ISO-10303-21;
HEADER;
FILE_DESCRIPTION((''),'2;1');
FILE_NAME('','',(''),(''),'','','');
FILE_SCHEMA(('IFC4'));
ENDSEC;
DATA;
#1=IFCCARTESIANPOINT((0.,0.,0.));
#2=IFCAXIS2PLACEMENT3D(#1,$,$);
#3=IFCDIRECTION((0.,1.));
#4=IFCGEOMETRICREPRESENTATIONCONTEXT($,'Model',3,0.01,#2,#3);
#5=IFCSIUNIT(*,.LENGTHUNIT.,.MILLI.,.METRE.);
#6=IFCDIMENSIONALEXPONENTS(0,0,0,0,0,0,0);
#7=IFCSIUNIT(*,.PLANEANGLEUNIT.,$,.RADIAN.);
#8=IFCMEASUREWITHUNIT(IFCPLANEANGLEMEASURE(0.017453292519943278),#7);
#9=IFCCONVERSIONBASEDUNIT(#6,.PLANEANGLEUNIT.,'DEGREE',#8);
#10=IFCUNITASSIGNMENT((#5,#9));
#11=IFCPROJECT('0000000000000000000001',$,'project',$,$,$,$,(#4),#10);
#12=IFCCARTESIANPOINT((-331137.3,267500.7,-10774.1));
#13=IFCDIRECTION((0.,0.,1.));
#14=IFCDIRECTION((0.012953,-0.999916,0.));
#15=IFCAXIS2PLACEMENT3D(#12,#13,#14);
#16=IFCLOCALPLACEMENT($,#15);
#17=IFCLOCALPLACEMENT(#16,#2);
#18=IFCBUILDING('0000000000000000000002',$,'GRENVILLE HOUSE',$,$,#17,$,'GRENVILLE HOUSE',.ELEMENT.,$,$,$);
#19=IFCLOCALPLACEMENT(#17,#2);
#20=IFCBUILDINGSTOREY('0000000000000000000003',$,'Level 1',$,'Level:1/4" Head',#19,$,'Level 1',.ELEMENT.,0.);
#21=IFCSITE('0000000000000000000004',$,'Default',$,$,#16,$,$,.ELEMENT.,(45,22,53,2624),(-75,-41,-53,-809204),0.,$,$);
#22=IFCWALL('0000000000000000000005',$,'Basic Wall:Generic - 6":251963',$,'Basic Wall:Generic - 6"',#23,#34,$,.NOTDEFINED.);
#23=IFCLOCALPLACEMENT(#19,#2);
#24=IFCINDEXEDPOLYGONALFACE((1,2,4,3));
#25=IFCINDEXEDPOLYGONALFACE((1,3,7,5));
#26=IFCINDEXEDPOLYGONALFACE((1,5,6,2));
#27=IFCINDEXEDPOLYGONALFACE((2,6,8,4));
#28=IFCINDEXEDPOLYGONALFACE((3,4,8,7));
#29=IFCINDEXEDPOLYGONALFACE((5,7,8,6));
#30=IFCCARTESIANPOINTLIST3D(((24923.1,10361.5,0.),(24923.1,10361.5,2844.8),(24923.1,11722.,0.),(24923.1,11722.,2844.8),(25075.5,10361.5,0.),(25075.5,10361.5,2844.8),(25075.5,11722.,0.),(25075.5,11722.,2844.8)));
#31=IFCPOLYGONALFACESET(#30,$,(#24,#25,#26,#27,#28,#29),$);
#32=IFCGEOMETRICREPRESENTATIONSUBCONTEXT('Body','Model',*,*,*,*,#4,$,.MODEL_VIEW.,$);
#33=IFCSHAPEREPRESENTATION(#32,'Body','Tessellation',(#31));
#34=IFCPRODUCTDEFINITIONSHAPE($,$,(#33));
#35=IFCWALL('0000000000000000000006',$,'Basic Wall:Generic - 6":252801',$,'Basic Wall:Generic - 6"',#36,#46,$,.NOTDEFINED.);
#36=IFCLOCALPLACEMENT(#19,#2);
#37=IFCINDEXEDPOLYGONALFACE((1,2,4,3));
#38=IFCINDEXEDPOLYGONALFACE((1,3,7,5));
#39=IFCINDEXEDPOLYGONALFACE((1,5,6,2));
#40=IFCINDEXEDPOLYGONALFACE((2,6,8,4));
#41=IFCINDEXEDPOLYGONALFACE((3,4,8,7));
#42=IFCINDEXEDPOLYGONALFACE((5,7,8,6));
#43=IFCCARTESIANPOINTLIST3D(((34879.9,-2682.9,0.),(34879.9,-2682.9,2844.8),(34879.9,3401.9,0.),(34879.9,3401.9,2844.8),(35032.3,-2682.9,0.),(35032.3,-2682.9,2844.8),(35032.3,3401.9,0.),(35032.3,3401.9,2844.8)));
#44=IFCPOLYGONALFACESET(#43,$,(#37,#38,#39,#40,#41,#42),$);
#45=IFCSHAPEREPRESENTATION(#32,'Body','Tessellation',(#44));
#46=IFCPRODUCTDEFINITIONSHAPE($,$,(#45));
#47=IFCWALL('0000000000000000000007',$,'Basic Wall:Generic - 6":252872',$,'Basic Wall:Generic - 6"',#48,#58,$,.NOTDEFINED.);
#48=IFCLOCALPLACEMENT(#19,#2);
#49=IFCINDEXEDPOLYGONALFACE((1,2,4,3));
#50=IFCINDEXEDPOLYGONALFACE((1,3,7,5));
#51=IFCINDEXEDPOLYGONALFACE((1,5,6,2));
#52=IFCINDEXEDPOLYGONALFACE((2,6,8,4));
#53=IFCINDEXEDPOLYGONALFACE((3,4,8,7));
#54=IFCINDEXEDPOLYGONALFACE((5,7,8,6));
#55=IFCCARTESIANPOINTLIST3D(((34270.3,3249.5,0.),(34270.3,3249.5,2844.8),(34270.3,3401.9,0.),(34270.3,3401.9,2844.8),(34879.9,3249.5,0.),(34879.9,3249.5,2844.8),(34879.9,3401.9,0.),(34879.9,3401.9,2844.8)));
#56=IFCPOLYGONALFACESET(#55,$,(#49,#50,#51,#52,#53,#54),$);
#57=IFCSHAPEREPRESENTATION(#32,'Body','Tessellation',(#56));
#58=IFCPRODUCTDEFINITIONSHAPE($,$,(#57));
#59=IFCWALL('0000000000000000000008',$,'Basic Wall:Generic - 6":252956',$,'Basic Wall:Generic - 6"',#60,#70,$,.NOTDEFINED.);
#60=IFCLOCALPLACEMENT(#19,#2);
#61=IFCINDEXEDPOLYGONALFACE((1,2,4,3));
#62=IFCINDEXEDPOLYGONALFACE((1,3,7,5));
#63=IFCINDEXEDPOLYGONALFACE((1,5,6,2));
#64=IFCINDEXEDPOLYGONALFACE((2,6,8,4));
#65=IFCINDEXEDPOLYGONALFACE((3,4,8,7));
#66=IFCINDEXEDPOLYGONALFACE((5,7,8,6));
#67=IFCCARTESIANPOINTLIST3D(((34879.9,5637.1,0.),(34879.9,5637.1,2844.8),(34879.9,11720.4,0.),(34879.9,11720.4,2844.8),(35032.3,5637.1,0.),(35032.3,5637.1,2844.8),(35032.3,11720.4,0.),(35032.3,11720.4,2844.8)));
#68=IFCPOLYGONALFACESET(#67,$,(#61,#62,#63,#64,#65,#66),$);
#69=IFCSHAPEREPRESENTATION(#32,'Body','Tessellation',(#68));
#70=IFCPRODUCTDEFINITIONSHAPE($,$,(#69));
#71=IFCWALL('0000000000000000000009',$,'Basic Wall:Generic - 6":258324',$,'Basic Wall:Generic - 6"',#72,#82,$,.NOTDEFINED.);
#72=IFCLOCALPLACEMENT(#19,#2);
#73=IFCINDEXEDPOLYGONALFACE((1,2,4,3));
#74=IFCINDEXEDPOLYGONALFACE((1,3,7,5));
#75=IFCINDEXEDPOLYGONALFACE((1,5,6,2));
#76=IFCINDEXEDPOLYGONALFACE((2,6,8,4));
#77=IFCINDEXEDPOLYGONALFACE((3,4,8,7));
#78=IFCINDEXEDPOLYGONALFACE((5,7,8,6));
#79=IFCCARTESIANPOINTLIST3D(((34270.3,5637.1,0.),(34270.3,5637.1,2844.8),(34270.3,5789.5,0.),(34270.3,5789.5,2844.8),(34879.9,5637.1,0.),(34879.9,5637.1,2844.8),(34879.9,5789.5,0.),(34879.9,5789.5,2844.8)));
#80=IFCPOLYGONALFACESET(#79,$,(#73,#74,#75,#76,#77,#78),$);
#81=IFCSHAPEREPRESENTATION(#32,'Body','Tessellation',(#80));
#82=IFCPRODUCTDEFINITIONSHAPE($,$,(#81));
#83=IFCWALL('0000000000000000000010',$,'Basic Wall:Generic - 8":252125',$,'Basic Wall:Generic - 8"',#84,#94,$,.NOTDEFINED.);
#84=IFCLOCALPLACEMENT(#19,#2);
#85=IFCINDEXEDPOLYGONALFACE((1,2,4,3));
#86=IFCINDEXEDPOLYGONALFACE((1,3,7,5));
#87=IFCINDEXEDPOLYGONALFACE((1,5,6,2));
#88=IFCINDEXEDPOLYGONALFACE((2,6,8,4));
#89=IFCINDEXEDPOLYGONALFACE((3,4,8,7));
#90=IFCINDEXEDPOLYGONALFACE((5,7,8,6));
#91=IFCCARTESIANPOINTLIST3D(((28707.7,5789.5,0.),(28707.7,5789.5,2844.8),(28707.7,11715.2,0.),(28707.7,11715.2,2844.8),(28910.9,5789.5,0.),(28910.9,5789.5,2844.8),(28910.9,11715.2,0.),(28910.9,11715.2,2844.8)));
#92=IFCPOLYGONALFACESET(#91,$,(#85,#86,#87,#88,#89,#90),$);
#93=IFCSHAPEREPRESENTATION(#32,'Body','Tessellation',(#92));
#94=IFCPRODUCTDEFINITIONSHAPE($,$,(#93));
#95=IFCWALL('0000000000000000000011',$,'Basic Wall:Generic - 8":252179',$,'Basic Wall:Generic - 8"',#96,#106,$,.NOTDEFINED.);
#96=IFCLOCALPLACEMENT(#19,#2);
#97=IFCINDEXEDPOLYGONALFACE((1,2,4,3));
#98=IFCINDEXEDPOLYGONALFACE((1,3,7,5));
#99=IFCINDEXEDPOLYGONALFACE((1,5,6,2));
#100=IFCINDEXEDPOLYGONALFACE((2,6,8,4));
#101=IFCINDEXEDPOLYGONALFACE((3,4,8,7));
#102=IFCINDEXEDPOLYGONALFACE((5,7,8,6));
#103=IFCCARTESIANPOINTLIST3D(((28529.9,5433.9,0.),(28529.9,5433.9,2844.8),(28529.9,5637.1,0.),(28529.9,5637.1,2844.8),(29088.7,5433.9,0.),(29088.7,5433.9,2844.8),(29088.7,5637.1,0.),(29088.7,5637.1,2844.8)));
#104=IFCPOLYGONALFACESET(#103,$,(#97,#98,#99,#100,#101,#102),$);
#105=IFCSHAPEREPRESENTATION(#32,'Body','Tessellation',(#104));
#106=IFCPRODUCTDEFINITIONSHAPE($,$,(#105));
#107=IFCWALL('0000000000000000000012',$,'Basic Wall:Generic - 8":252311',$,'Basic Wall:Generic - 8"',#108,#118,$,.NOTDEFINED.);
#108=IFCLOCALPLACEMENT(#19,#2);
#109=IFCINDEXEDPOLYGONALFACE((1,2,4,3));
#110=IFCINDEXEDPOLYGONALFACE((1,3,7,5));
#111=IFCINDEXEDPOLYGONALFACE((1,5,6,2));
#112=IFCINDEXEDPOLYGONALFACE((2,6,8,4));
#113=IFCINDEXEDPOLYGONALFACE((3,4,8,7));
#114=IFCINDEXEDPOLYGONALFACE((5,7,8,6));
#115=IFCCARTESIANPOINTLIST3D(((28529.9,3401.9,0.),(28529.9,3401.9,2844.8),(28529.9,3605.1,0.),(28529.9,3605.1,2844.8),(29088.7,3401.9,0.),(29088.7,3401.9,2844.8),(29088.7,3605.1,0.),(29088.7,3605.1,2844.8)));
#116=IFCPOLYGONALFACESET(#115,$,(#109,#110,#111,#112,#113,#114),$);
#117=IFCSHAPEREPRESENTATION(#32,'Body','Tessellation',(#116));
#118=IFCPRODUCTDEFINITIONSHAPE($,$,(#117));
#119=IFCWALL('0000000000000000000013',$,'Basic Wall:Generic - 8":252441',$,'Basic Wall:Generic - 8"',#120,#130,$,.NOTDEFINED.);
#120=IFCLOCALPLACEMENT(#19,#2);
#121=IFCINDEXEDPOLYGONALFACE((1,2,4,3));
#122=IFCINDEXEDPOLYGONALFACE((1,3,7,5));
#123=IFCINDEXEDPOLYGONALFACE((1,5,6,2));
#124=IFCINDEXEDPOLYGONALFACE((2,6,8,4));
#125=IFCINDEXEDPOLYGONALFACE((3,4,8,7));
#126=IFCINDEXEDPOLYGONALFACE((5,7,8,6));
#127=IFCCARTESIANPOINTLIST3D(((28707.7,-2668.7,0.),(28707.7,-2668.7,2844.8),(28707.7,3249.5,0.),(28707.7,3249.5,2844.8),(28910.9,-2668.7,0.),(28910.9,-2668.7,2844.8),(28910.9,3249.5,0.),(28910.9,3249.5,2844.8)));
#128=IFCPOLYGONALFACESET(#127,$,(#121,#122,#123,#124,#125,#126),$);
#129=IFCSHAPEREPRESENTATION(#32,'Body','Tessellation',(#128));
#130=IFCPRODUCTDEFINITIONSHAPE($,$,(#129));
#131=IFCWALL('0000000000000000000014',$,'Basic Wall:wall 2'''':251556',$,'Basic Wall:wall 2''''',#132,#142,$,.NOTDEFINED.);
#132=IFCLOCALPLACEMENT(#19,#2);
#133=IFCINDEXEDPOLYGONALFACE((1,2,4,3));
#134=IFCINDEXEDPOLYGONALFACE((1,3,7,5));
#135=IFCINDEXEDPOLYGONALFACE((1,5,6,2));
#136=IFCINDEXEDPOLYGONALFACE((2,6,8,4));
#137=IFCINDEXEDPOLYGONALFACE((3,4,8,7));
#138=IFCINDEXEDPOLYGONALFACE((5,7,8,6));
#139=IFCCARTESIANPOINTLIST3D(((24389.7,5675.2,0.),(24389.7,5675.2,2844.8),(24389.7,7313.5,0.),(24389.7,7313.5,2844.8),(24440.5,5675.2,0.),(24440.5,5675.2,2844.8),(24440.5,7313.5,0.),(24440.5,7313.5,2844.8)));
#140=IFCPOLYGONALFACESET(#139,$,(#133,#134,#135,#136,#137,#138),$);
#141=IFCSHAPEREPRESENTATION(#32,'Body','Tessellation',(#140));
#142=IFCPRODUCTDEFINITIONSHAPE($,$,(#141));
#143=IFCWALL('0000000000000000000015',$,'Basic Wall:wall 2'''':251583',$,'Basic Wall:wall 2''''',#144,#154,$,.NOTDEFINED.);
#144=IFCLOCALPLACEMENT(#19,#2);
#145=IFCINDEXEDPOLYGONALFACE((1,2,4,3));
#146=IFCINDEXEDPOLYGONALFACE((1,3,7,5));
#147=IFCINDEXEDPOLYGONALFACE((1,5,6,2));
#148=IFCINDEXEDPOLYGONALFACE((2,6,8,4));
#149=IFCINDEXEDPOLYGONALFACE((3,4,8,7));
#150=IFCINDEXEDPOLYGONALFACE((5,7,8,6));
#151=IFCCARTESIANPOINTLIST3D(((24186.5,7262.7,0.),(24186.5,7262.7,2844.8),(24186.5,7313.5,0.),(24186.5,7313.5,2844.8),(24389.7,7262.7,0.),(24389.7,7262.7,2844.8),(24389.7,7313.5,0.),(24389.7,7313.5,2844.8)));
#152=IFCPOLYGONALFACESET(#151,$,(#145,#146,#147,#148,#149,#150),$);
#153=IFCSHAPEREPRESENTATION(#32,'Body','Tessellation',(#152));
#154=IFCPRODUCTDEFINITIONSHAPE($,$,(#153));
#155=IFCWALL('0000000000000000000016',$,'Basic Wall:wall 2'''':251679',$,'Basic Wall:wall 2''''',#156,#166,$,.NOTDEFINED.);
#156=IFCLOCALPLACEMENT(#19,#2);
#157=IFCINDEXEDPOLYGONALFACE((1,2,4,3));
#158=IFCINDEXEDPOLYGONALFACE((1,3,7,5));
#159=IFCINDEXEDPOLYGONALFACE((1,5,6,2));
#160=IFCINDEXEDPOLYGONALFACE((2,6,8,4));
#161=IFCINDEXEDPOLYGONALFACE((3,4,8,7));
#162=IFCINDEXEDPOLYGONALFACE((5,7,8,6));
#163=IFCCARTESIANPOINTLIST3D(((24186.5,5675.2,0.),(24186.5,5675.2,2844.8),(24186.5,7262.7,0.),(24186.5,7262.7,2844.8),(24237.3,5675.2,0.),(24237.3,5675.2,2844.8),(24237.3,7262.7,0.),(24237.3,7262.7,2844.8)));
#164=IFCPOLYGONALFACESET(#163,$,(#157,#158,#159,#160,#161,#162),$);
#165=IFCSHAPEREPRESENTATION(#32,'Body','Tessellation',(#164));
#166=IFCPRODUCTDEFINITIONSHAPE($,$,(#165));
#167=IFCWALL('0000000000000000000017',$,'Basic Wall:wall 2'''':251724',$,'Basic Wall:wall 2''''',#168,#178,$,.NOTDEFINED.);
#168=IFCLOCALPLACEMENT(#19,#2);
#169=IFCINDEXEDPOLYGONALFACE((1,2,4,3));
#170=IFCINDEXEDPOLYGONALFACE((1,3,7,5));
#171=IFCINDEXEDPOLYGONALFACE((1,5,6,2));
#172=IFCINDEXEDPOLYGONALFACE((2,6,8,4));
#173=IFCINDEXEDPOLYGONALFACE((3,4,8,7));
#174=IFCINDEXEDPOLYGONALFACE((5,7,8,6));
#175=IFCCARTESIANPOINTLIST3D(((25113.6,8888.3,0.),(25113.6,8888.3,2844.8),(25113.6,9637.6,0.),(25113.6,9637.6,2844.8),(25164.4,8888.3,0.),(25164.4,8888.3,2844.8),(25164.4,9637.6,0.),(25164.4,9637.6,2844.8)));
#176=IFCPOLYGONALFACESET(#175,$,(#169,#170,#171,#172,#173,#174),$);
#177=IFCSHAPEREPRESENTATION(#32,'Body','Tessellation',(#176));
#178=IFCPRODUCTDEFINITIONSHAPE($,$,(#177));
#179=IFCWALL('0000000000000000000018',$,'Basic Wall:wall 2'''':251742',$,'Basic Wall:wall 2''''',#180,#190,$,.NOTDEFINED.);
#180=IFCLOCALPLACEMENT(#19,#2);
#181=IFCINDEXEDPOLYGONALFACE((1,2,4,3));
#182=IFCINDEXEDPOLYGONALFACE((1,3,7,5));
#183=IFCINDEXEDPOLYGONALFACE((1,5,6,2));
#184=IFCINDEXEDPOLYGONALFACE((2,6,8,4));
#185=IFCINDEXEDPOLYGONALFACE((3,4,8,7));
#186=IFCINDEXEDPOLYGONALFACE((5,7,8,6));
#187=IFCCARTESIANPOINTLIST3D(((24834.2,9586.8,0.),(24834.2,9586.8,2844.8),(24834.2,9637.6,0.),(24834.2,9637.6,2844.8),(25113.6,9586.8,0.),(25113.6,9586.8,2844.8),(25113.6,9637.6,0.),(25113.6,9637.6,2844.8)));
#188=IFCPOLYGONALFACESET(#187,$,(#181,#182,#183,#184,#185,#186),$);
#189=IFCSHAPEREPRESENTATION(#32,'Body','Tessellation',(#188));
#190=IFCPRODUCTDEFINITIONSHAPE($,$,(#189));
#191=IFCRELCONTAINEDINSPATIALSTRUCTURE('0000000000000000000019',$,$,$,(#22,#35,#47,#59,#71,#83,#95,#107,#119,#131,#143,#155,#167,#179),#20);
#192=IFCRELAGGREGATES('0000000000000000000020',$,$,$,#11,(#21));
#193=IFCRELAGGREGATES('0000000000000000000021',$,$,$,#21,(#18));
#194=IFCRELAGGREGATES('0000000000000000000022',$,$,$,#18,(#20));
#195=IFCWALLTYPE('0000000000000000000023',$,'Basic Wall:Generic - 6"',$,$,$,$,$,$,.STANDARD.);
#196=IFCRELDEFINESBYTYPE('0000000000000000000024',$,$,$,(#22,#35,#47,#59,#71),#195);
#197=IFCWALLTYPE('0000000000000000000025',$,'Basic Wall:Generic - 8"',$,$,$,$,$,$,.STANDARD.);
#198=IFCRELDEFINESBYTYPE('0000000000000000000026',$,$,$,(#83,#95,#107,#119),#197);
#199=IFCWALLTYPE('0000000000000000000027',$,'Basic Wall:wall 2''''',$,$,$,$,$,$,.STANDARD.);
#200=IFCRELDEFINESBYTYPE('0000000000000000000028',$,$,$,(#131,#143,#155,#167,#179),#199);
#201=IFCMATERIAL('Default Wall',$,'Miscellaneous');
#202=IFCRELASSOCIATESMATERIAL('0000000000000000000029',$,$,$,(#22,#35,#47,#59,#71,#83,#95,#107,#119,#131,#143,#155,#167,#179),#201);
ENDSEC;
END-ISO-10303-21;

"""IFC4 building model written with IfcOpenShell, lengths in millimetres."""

from ifc_helpers import new_model, entity, si_unit, converted_unit, direction, frame, origin, place, context, subcontext, project, spatial, indexed_curve, outline, extrude, material, type_object, element, save


model = new_model("IFC4")

# Units and contexts
model_context = context("Model", 3, precision=0.01, world=origin(), true_north=direction((0.0, 1.0)))
body_context = subcontext(model_context, "Body", "Model", "MODEL_VIEW")
ifc_project = project(units=[si_unit("LENGTHUNIT", "METRE", prefix="MILLI"), converted_unit("PLANEANGLEUNIT", "DEGREE", entity("IfcPlaneAngleMeasure", 0.017453292519943278), si_unit("PLANEANGLEUNIT", "RADIAN"), dimensions=[0, 0, 0, 0, 0, 0, 0])], contexts=[model_context])

# Site, building, storey
site_placement = place(None, frame((-331137.3, 267500.7, -10774.1), z_axis=(0.0, 0.0, 1.0), x_axis=(0.012953, -0.999916, 0.0)))
site = spatial("IfcSite", under=ifc_project, at=site_placement, Name="Default", CompositionType="ELEMENT", RefLatitude=(45, 22, 53, 2624), RefLongitude=(-75, -41, -53, -809204), RefElevation=0.0)
building_placement = place(site_placement, origin())
building = spatial("IfcBuilding", under=site, at=building_placement, Name="GRENVILLE HOUSE", LongName="GRENVILLE HOUSE", CompositionType="ELEMENT")
storey_placement = place(building_placement, origin())
storey = spatial("IfcBuildingStorey", under=building, at=storey_placement, Name="Level 1", ObjectType="Level:1/4\" Head", LongName="Level 1", CompositionType="ELEMENT", Elevation=0.0)

# Walls
ifc_material = material(Name="Default Wall", Category="Miscellaneous")
wall_type_1 = type_object("IfcWallType", Name="Basic Wall:Generic - 6\"", PredefinedType="STANDARD")
wall_1_placement = place(storey_placement, frame((24999.3, 11722.0, 0.0), z_axis=(0.0, 0.0, 1.0), x_axis=(0.0, -1.0, 0.0)))
element("IfcWall", 1, at=wall_1_placement, inside=storey, type_object=wall_type_1, material=ifc_material, Name="Basic Wall:Generic - 6\":251963", ObjectType="Basic Wall:Generic - 6\"", PredefinedType="NOTDEFINED", context=body_context, shape_type="SweptSolid", body=[
    extrude(outline(indexed_curve([(1360.5, 76.2), (0.0, 76.2), (0.0, -76.2), (1360.5, -76.2), (1360.5, 76.2)], self_intersect=False)), origin(), (0.0, 0.0, 1.0), 2844.8),
])
wall_2_placement = place(storey_placement, frame((34956.1, 3401.9, 0.0), z_axis=(0.0, 0.0, 1.0), x_axis=(0.0, -1.0, 0.0)))
element("IfcWall", 2, at=wall_2_placement, inside=storey, type_object=wall_type_1, material=ifc_material, Name="Basic Wall:Generic - 6\":252801", ObjectType="Basic Wall:Generic - 6\"", PredefinedType="NOTDEFINED", context=body_context, shape_type="SweptSolid", body=[
    extrude(outline(indexed_curve([(6084.9, 76.2), (0.0, 76.2), (0.0, -76.2), (6084.9, -76.2), (6084.9, 76.2)], self_intersect=False)), origin(), (0.0, 0.0, 1.0), 2844.8),
])
wall_3_placement = place(storey_placement, frame((34270.3, 3325.7, 0.0)))
element("IfcWall", 3, at=wall_3_placement, inside=storey, type_object=wall_type_1, material=ifc_material, Name="Basic Wall:Generic - 6\":252872", ObjectType="Basic Wall:Generic - 6\"", PredefinedType="NOTDEFINED", context=body_context, shape_type="SweptSolid", body=[
    extrude(outline(indexed_curve([(609.6, 76.2), (0.0, 76.2), (0.0, -76.2), (609.6, -76.2), (609.6, 76.2)], self_intersect=False)), origin(), (0.0, 0.0, 1.0), 2844.8),
])
wall_4_placement = place(storey_placement, frame((34956.1, 5637.1, 0.0), z_axis=(0.0, 0.0, 1.0), x_axis=(0.0, 1.0, 0.0)))
element("IfcWall", 4, at=wall_4_placement, inside=storey, type_object=wall_type_1, material=ifc_material, Name="Basic Wall:Generic - 6\":252956", ObjectType="Basic Wall:Generic - 6\"", PredefinedType="NOTDEFINED", context=body_context, shape_type="SweptSolid", body=[
    extrude(outline(indexed_curve([(6083.3, 76.2), (0.0, 76.2), (0.0, -76.2), (6083.3, -76.2), (6083.3, 76.2)], self_intersect=False)), origin(), (0.0, 0.0, 1.0), 2844.8),
])
wall_5_placement = place(storey_placement, frame((34879.9, 5713.3, 0.0), z_axis=(0.0, 0.0, 1.0), x_axis=(-1.0, 0.0, 0.0)))
element("IfcWall", 5, at=wall_5_placement, inside=storey, type_object=wall_type_1, material=ifc_material, Name="Basic Wall:Generic - 6\":258324", ObjectType="Basic Wall:Generic - 6\"", PredefinedType="NOTDEFINED", context=body_context, shape_type="SweptSolid", body=[
    extrude(outline(indexed_curve([(609.6, 76.2), (0.0, 76.2), (0.0, -76.2), (609.6, -76.2), (609.6, 76.2)], self_intersect=False)), origin(), (0.0, 0.0, 1.0), 2844.8),
])
wall_type_2 = type_object("IfcWallType", Name="Basic Wall:Generic - 8\"", PredefinedType="STANDARD")
wall_6_placement = place(storey_placement, frame((28809.3, 11715.2, 0.0), z_axis=(0.0, 0.0, 1.0), x_axis=(0.0, -1.0, 0.0)))
element("IfcWall", 6, at=wall_6_placement, inside=storey, type_object=wall_type_2, material=ifc_material, Name="Basic Wall:Generic - 8\":252125", ObjectType="Basic Wall:Generic - 8\"", PredefinedType="NOTDEFINED", context=body_context, shape_type="SweptSolid", body=[
    extrude(outline(indexed_curve([(5925.6, 101.6), (0.0, 101.6), (0.0, -101.6), (5925.6, -101.6), (5925.6, 101.6)], self_intersect=False)), origin(), (0.0, 0.0, 1.0), 2844.8),
])
wall_7_placement = place(storey_placement, frame((28529.9, 5535.5, 0.0)))
element("IfcWall", 7, at=wall_7_placement, inside=storey, type_object=wall_type_2, material=ifc_material, Name="Basic Wall:Generic - 8\":252179", ObjectType="Basic Wall:Generic - 8\"", PredefinedType="NOTDEFINED", context=body_context, shape_type="SweptSolid", body=[
    extrude(outline(indexed_curve([(558.8, 101.6), (0.0, 101.6), (0.0, -101.6), (558.8, -101.6), (558.8, 101.6)], self_intersect=False)), origin(), (0.0, 0.0, 1.0), 2844.8),
])
wall_8_placement = place(storey_placement, frame((29088.7, 3503.5, 0.0), z_axis=(0.0, 0.0, 1.0), x_axis=(-1.0, 0.0, 0.0)))
element("IfcWall", 8, at=wall_8_placement, inside=storey, type_object=wall_type_2, material=ifc_material, Name="Basic Wall:Generic - 8\":252311", ObjectType="Basic Wall:Generic - 8\"", PredefinedType="NOTDEFINED", context=body_context, shape_type="SweptSolid", body=[
    extrude(outline(indexed_curve([(558.8, 101.6), (0.0, 101.6), (0.0, -101.6), (558.8, -101.6), (558.8, 101.6)], self_intersect=False)), origin(), (0.0, 0.0, 1.0), 2844.8),
])
wall_9_placement = place(storey_placement, frame((28809.3, 3249.5, 0.0), z_axis=(0.0, 0.0, 1.0), x_axis=(0.0, -1.0, 0.0)))
element("IfcWall", 9, at=wall_9_placement, inside=storey, type_object=wall_type_2, material=ifc_material, Name="Basic Wall:Generic - 8\":252441", ObjectType="Basic Wall:Generic - 8\"", PredefinedType="NOTDEFINED", context=body_context, shape_type="SweptSolid", body=[
    extrude(outline(indexed_curve([(5918.2, 101.6), (0.0, 101.6), (0.0, -101.6), (5918.2, -101.6), (5918.2, 101.6)], self_intersect=False)), origin(), (0.0, 0.0, 1.0), 2844.8),
])
wall_type_3 = type_object("IfcWallType", Name="Basic Wall:wall 2''", PredefinedType="STANDARD")
wall_10_placement = place(storey_placement, frame((24415.1, 5675.2, 0.0), z_axis=(0.0, 0.0, 1.0), x_axis=(0.0, 1.0, 0.0)))
element("IfcWall", 10, at=wall_10_placement, inside=storey, type_object=wall_type_3, material=ifc_material, Name="Basic Wall:wall 2'':251556", ObjectType="Basic Wall:wall 2''", PredefinedType="NOTDEFINED", context=body_context, shape_type="SweptSolid", body=[
    extrude(outline(indexed_curve([(1638.3, 25.4), (0.0, 25.4), (0.0, -25.4), (1638.3, -25.4), (1638.3, 25.4)], self_intersect=False)), origin(), (0.0, 0.0, 1.0), 2844.8),
])
wall_11_placement = place(storey_placement, frame((24389.7, 7288.1, 0.0), z_axis=(0.0, 0.0, 1.0), x_axis=(-1.0, 0.0, 0.0)))
element("IfcWall", 11, at=wall_11_placement, inside=storey, type_object=wall_type_3, material=ifc_material, Name="Basic Wall:wall 2'':251583", ObjectType="Basic Wall:wall 2''", PredefinedType="NOTDEFINED", context=body_context, shape_type="SweptSolid", body=[
    extrude(outline(indexed_curve([(203.2, 25.4), (0.0, 25.4), (0.0, -25.4), (203.2, -25.4), (203.2, 25.4)], self_intersect=False)), origin(), (0.0, 0.0, 1.0), 2844.8),
])
wall_12_placement = place(storey_placement, frame((24211.9, 7262.7, 0.0), z_axis=(0.0, 0.0, 1.0), x_axis=(0.0, -1.0, 0.0)))
element("IfcWall", 12, at=wall_12_placement, inside=storey, type_object=wall_type_3, material=ifc_material, Name="Basic Wall:wall 2'':251679", ObjectType="Basic Wall:wall 2''", PredefinedType="NOTDEFINED", context=body_context, shape_type="SweptSolid", body=[
    extrude(outline(indexed_curve([(1587.5, 25.4), (0.0, 25.4), (0.0, -25.4), (1587.5, -25.4), (1587.5, 25.4)], self_intersect=False)), origin(), (0.0, 0.0, 1.0), 2844.8),
])
wall_13_placement = place(storey_placement, frame((25139.0, 8888.3, 0.0), z_axis=(0.0, 0.0, 1.0), x_axis=(0.0, 1.0, 0.0)))
element("IfcWall", 13, at=wall_13_placement, inside=storey, type_object=wall_type_3, material=ifc_material, Name="Basic Wall:wall 2'':251724", ObjectType="Basic Wall:wall 2''", PredefinedType="NOTDEFINED", context=body_context, shape_type="SweptSolid", body=[
    extrude(outline(indexed_curve([(749.3, 25.4), (0.0, 25.4), (0.0, -25.4), (749.3, -25.4), (749.3, 25.4)], self_intersect=False)), origin(), (0.0, 0.0, 1.0), 2844.8),
])
wall_14_placement = place(storey_placement, frame((25113.6, 9612.2, 0.0), z_axis=(0.0, 0.0, 1.0), x_axis=(-1.0, 0.0, 0.0)))
element("IfcWall", 14, at=wall_14_placement, inside=storey, type_object=wall_type_3, material=ifc_material, Name="Basic Wall:wall 2'':251742", ObjectType="Basic Wall:wall 2''", PredefinedType="NOTDEFINED", context=body_context, shape_type="SweptSolid", body=[
    extrude(outline(indexed_curve([(279.4, 25.4), (0.0, 25.4), (0.0, -25.4), (279.4, -25.4), (279.4, 25.4)], self_intersect=False)), origin(), (0.0, 0.0, 1.0), 2844.8),
])

save(model, "model.ifc")
